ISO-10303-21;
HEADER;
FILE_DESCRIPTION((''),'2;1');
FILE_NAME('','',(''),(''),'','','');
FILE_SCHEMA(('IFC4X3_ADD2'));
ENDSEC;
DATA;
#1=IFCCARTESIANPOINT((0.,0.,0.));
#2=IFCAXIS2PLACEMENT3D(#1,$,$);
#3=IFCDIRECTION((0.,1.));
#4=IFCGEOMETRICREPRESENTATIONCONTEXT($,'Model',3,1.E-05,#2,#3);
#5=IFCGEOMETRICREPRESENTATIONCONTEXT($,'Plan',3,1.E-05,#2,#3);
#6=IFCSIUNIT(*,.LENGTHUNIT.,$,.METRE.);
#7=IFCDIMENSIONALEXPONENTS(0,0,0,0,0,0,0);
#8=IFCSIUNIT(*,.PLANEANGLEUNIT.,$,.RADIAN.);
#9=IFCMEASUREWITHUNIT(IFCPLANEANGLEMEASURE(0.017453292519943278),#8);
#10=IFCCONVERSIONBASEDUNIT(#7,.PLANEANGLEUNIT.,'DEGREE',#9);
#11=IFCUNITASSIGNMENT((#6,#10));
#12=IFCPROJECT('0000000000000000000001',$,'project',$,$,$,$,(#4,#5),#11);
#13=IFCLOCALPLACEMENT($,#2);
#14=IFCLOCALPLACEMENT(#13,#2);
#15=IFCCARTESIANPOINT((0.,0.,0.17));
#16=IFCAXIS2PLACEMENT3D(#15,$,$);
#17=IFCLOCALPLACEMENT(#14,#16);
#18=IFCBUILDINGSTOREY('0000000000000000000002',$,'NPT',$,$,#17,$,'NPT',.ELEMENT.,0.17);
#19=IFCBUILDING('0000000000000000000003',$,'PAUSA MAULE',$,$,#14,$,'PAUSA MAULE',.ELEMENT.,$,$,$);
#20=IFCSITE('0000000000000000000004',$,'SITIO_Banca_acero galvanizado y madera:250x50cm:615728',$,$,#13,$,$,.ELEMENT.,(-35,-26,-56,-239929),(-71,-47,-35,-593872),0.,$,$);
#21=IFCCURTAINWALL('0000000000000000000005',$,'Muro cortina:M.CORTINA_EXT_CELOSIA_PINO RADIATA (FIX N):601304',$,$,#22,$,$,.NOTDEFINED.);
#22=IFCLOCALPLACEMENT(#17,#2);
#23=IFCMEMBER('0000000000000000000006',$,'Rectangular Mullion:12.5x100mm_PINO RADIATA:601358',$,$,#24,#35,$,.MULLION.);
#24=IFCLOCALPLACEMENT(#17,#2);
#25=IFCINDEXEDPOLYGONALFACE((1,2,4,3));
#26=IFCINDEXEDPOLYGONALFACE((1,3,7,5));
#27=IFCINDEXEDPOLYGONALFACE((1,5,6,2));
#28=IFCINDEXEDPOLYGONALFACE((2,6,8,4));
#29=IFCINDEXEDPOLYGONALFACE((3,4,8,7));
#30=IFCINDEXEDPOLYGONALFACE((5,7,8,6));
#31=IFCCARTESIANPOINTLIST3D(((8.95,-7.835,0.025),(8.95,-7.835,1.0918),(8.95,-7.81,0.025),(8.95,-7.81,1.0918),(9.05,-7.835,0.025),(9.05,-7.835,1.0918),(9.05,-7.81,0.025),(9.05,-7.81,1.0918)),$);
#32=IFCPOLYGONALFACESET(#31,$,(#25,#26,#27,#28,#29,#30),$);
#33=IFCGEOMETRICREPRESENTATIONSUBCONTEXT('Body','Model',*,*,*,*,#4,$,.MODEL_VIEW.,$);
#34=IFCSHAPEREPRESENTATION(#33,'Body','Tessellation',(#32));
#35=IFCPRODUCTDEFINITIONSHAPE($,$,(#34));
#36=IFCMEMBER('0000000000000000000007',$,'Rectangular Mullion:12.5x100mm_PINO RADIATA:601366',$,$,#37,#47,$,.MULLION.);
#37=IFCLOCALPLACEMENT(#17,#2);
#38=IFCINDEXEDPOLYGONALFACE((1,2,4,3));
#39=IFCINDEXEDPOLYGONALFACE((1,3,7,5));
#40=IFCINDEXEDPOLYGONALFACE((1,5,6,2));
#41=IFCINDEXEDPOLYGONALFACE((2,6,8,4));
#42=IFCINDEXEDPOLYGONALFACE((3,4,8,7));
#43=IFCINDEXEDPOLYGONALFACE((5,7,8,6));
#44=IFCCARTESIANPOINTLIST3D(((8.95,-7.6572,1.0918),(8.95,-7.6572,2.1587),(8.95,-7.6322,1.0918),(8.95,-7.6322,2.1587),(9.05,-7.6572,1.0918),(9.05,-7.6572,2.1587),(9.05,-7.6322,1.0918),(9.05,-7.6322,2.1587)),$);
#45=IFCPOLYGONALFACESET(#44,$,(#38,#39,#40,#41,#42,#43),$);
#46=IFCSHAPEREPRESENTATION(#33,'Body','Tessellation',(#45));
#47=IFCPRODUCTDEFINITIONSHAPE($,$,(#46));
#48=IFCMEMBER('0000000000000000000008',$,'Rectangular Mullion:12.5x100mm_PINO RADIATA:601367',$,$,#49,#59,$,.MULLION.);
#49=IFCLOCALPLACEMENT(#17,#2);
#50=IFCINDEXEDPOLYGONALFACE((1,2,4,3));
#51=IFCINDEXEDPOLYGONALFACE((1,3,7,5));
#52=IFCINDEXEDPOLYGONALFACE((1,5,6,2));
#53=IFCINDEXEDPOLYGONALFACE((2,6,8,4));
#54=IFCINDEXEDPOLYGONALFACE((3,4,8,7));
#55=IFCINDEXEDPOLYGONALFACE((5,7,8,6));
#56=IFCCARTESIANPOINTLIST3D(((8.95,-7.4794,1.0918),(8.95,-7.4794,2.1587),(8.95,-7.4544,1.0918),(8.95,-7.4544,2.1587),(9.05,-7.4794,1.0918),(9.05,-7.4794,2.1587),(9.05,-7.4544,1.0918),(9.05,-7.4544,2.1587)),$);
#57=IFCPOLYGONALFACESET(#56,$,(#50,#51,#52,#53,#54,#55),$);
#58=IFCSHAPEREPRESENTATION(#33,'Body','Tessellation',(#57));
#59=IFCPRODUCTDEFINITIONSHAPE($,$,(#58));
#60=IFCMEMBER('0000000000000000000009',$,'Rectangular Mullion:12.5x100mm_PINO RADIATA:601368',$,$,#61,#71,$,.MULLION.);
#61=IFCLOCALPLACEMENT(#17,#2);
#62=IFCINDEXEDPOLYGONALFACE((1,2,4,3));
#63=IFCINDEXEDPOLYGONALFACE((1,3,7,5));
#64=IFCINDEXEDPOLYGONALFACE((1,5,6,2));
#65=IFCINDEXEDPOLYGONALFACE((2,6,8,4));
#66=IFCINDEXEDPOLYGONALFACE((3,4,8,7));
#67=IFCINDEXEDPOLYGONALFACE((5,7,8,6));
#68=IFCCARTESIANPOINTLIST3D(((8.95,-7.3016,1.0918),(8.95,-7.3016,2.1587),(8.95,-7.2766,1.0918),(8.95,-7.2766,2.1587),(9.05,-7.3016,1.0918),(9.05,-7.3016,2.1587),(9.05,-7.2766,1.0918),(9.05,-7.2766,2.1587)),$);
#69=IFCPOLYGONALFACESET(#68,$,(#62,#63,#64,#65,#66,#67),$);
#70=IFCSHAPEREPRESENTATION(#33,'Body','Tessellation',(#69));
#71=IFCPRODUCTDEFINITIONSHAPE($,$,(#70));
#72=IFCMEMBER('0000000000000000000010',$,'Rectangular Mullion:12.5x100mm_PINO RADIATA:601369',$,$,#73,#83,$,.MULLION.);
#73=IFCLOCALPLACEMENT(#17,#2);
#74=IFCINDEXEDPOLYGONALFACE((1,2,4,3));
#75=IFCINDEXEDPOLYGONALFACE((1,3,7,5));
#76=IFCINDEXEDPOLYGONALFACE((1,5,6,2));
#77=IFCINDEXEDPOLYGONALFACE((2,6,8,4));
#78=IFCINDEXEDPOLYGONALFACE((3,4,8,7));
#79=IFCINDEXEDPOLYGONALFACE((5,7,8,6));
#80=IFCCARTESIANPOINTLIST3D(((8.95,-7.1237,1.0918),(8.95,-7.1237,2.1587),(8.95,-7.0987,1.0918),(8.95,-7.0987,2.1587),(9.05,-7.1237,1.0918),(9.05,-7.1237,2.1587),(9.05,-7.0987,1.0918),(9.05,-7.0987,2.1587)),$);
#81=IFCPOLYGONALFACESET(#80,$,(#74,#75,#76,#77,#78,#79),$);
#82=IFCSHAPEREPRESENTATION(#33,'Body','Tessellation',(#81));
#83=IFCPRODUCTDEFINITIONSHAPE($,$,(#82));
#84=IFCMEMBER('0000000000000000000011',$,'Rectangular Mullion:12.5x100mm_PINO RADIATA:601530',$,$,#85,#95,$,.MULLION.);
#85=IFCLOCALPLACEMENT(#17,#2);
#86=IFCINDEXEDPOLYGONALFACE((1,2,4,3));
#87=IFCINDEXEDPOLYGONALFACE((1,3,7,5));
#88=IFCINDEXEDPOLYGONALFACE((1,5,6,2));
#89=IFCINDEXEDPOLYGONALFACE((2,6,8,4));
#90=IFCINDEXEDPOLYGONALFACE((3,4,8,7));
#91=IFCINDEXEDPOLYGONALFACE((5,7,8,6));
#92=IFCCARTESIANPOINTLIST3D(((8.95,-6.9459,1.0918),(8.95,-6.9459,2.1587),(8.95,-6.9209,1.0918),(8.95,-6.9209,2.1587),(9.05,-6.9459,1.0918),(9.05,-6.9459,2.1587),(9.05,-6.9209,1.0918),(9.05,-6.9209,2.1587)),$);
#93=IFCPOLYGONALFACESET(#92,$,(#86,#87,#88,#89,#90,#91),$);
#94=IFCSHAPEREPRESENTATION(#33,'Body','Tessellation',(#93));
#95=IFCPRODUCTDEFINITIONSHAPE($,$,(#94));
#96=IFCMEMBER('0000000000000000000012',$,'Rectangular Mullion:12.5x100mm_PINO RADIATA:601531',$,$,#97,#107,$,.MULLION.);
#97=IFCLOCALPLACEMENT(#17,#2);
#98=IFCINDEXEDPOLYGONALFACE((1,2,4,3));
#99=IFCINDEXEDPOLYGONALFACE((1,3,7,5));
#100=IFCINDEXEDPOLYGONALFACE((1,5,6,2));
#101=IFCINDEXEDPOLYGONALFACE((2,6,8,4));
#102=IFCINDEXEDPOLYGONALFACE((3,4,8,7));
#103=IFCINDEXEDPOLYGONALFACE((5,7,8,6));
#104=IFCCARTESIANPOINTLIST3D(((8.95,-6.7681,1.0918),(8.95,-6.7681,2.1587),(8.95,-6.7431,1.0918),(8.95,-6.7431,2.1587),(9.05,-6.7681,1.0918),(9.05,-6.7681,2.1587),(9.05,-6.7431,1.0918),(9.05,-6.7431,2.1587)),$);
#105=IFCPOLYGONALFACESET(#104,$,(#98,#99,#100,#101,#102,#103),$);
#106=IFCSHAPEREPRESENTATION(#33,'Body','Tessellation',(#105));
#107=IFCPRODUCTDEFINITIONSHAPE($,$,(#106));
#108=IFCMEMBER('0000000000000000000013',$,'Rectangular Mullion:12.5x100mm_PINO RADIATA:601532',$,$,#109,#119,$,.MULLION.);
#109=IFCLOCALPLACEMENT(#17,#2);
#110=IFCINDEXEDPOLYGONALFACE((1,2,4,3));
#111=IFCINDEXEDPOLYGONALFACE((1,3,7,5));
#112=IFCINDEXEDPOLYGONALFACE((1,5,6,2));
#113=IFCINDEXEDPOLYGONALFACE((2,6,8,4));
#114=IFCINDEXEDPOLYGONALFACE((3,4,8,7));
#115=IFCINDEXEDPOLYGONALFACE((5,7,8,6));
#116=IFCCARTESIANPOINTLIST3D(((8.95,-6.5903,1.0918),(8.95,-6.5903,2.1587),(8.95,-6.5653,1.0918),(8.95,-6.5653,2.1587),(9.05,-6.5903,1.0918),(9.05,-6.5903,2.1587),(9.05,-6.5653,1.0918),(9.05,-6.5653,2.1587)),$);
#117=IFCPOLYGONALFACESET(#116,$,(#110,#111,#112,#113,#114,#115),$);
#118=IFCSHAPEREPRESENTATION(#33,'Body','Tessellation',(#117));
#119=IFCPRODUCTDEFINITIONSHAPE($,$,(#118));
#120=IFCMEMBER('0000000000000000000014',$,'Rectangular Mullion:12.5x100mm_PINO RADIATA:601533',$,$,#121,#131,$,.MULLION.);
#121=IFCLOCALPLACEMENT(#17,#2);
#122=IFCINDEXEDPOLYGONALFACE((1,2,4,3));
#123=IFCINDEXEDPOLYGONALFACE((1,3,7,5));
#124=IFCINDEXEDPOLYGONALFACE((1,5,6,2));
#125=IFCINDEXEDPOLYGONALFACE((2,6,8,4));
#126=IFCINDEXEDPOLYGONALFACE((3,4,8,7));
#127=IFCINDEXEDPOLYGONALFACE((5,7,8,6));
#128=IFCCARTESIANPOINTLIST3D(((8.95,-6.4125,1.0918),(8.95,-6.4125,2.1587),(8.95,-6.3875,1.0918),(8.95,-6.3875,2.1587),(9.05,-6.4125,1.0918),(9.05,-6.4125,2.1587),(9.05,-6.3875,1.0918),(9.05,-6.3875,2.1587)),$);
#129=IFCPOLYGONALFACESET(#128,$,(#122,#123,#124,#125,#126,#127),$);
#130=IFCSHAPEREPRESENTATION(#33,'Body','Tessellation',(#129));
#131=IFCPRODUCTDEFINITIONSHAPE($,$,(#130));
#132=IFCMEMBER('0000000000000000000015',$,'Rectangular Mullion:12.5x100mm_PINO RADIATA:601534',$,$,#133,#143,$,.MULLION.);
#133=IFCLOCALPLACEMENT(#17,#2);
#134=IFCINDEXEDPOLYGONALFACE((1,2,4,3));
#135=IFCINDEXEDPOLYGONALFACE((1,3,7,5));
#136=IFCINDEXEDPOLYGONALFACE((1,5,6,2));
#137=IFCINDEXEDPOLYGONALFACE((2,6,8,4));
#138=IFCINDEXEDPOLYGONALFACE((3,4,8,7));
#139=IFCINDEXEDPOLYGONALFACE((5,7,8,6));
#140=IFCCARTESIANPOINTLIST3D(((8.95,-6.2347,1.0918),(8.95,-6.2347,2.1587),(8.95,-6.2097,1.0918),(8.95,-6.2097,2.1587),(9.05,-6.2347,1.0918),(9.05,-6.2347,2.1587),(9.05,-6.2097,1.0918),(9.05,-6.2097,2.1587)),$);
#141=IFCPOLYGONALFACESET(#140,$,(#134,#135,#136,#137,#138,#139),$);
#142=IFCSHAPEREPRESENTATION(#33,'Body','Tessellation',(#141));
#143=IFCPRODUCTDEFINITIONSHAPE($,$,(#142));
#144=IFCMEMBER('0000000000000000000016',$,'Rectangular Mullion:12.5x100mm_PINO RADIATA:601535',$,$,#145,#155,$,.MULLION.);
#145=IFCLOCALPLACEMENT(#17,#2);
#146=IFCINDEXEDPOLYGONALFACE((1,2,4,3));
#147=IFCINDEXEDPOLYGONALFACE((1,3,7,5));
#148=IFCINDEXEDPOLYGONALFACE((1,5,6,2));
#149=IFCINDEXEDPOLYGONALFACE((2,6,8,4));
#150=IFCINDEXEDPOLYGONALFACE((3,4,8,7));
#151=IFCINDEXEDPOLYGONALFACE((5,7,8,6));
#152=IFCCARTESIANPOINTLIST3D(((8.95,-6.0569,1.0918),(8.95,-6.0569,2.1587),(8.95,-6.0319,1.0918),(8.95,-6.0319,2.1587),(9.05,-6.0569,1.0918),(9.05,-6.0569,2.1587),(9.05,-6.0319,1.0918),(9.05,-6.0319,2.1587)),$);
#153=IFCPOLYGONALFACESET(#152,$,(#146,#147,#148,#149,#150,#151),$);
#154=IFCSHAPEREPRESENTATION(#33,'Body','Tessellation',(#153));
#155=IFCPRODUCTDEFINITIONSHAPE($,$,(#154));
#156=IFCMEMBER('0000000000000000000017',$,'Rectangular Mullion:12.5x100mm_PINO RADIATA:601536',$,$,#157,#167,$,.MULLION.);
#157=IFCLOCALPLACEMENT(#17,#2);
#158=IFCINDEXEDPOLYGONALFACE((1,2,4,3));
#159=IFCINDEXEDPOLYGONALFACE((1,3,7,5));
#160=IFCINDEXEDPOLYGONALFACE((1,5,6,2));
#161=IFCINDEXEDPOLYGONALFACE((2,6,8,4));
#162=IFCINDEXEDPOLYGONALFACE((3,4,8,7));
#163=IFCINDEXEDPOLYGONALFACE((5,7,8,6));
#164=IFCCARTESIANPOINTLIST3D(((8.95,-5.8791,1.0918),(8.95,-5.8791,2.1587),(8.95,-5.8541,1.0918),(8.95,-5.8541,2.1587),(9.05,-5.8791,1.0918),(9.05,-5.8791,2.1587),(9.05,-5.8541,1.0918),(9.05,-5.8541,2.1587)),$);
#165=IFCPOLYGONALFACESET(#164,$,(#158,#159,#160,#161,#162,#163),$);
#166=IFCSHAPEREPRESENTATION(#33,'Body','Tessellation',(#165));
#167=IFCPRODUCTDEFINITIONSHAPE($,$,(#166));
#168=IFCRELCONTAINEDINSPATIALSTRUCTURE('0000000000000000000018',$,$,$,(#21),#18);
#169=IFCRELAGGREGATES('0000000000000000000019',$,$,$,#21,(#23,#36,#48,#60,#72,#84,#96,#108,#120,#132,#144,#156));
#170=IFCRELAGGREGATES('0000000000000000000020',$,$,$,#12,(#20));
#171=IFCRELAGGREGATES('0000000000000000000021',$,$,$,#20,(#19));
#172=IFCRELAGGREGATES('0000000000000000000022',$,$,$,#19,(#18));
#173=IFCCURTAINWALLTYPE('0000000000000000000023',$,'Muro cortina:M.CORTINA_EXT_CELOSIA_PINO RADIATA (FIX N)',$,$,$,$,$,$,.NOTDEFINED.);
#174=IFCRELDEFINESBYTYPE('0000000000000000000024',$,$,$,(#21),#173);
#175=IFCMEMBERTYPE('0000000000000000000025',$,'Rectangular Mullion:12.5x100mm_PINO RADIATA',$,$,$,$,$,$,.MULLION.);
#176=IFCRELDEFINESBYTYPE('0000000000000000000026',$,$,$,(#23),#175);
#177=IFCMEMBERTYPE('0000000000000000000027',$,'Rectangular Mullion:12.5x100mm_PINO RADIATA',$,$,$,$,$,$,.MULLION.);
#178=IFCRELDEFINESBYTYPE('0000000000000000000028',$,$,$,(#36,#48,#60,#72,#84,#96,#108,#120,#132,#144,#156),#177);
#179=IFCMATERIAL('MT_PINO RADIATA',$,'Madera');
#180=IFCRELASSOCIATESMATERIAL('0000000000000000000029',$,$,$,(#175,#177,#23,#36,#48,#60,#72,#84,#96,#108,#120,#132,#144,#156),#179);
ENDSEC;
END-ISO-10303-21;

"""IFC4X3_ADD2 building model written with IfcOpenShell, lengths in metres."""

from ifc_helpers import new_model, entity, si_unit, converted_unit, direction, frame, frame_2d, origin, origin_2d_with_axis, place, context, subcontext, project, spatial, rectangle, extrude, source, transform, mapped, material, material_profile, profile_set, profile_usage, type_object, type_shapes, element, aggregate, save


model = new_model("IFC4X3_ADD2")

# Units and contexts
model_context = context("Model", 3, precision=1e-05, world=origin(), true_north=direction((0.0, 1.0)))
plan_context = context("Plan", 3, precision=1e-05, world=origin(), true_north=direction((0.0, 1.0)))
body_context = subcontext(model_context, "Body", "Model", "MODEL_VIEW")
ifc_project = project(units=[si_unit("LENGTHUNIT", "METRE"), converted_unit("PLANEANGLEUNIT", "DEGREE", entity("IfcPlaneAngleMeasure", 0.017453292519943278), si_unit("PLANEANGLEUNIT", "RADIAN"), dimensions=[0, 0, 0, 0, 0, 0, 0])], contexts=[model_context, plan_context])

# Site, building, storey
site_placement = place(None, origin())
site = spatial("IfcSite", under=ifc_project, at=site_placement, Name="SITIO_Banca_acero galvanizado y madera:250x50cm:615728", CompositionType="ELEMENT", RefLatitude=(-35, -26, -56, -239929), RefLongitude=(-71, -47, -35, -593872), RefElevation=0.0)
building_placement = place(site_placement, origin())
building = spatial("IfcBuilding", under=site, at=building_placement, Name="PAUSA MAULE", LongName="PAUSA MAULE", CompositionType="ELEMENT")
storey_placement = place(building_placement, frame((0.0, 0.0, 0.17)))
storey = spatial("IfcBuildingStorey", under=building, at=storey_placement, Name="NPT", LongName="NPT", CompositionType="ELEMENT", Elevation=0.17)

# Curtain wall, members
curtain_wall_type = type_object("IfcCurtainWallType", Name="Muro cortina:M.CORTINA_EXT_CELOSIA_PINO RADIATA (FIX N)", PredefinedType="NOTDEFINED")
curtain_wall_placement = place(storey_placement, frame((0.0, 0.0, -0.17)))
curtain_wall = element("IfcCurtainWall", 1, at=curtain_wall_placement, inside=storey, type_object=curtain_wall_type, Name="Muro cortina:M.CORTINA_EXT_CELOSIA_PINO RADIATA (FIX N):601304", PredefinedType="NOTDEFINED")
ifc_material = material(Name="MT_PINO RADIATA", Category="Madera")
ifc_material_profile = material_profile(ifc_material, rectangle(XDim=0.025, YDim=0.1, at=frame_2d((0.0, 0.0), x_axis=(1.0, 0.0))), Name="12.5x100mm_PINO RADIATA")
ifc_profile_set = profile_set([ifc_material_profile], Name="12.5x100mm_PINO RADIATA")
ifc_profile_usage = profile_usage(ifc_profile_set)
member_type_1 = type_object("IfcMemberType", Name="Rectangular Mullion:12.5x100mm_PINO RADIATA", PredefinedType="MULLION", material=ifc_profile_set)
shared_shape_1 = source(origin(), body_context, "Body", "SweptSolid", [
    extrude(rectangle(XDim=0.025, YDim=0.1, at=frame_2d((0.0, 0.0), x_axis=(1.0, 0.0))), frame((-0.0125, 0.0, -1.0668), z_axis=(0.0, 0.0, 1.0), x_axis=(-1.0, 0.0, 0.0)), (0.0, 0.0, 1.0), 1.0668),
])
type_shapes(member_type_1, [shared_shape_1])
member_1_placement = place(curtain_wall_placement, frame((9.0, -7.835, 1.2618), z_axis=(0.0, 0.0, 1.0), x_axis=(0.0, -1.0, 0.0)))
member_1 = element("IfcMember", 2, at=member_1_placement, type_object=member_type_1, material=ifc_profile_usage, Name="Rectangular Mullion:12.5x100mm_PINO RADIATA:601358", PredefinedType="MULLION", context=body_context, shape_type="MappedRepresentation", body=[
    mapped(shared_shape_1, transform((0.0, 0.0, 0.0), scale=1.0)),
])
member_type_2 = type_object("IfcMemberType", Name="Rectangular Mullion:12.5x100mm_PINO RADIATA", PredefinedType="MULLION", material=ifc_profile_set)
shared_shape_2 = source(origin(), body_context, "Body", "SweptSolid", [
    extrude(rectangle(XDim=0.025, YDim=0.1, at=origin_2d_with_axis()), frame((0.0, 0.0, -1.0668), z_axis=(0.0, 0.0, 1.0), x_axis=(-1.0, 0.0, 0.0)), (0.0, 0.0, 1.0), 1.0668),
])
type_shapes(member_type_2, [shared_shape_2])
member_2_placement = place(curtain_wall_placement, frame((9.0, -7.6447, 1.2618), z_axis=(0.0, 0.0, -1.0), x_axis=(0.0, 1.0, 0.0)))
member_2 = element("IfcMember", 3, at=member_2_placement, type_object=member_type_2, material=ifc_profile_usage, Name="Rectangular Mullion:12.5x100mm_PINO RADIATA:601366", PredefinedType="MULLION", context=body_context, shape_type="MappedRepresentation", body=[
    mapped(shared_shape_2, transform((0.0, 0.0, 0.0), scale=1.0)),
])
member_3_placement = place(curtain_wall_placement, frame((9.0, -7.4669, 1.2618), z_axis=(0.0, 0.0, -1.0), x_axis=(0.0, 1.0, 0.0)))
member_3 = element("IfcMember", 4, at=member_3_placement, type_object=member_type_2, material=ifc_profile_usage, Name="Rectangular Mullion:12.5x100mm_PINO RADIATA:601367", PredefinedType="MULLION", context=body_context, shape_type="MappedRepresentation", body=[
    mapped(shared_shape_2, transform((0.0, 0.0, 0.0), scale=1.0)),
])
member_4_placement = place(curtain_wall_placement, frame((9.0, -7.2891, 1.2618), z_axis=(0.0, 0.0, -1.0), x_axis=(0.0, 1.0, 0.0)))
member_4 = element("IfcMember", 5, at=member_4_placement, type_object=member_type_2, material=ifc_profile_usage, Name="Rectangular Mullion:12.5x100mm_PINO RADIATA:601368", PredefinedType="MULLION", context=body_context, shape_type="MappedRepresentation", body=[
    mapped(shared_shape_2, transform((0.0, 0.0, 0.0), scale=1.0)),
])
member_5_placement = place(curtain_wall_placement, frame((9.0, -7.1112, 1.2618), z_axis=(0.0, 0.0, -1.0), x_axis=(0.0, 1.0, 0.0)))
member_5 = element("IfcMember", 6, at=member_5_placement, type_object=member_type_2, material=ifc_profile_usage, Name="Rectangular Mullion:12.5x100mm_PINO RADIATA:601369", PredefinedType="MULLION", context=body_context, shape_type="MappedRepresentation", body=[
    mapped(shared_shape_2, transform((0.0, 0.0, 0.0), scale=1.0)),
])
member_6_placement = place(curtain_wall_placement, frame((9.0, -6.9334, 1.2618), z_axis=(0.0, 0.0, -1.0), x_axis=(0.0, 1.0, 0.0)))
member_6 = element("IfcMember", 7, at=member_6_placement, type_object=member_type_2, material=ifc_profile_usage, Name="Rectangular Mullion:12.5x100mm_PINO RADIATA:601530", PredefinedType="MULLION", context=body_context, shape_type="MappedRepresentation", body=[
    mapped(shared_shape_2, transform((0.0, 0.0, 0.0), scale=1.0)),
])
member_7_placement = place(curtain_wall_placement, frame((9.0, -6.7556, 1.2618), z_axis=(0.0, 0.0, -1.0), x_axis=(0.0, 1.0, 0.0)))
member_7 = element("IfcMember", 8, at=member_7_placement, type_object=member_type_2, material=ifc_profile_usage, Name="Rectangular Mullion:12.5x100mm_PINO RADIATA:601531", PredefinedType="MULLION", context=body_context, shape_type="MappedRepresentation", body=[
    mapped(shared_shape_2, transform((0.0, 0.0, 0.0), scale=1.0)),
])
member_8_placement = place(curtain_wall_placement, frame((9.0, -6.5778, 1.2618), z_axis=(0.0, 0.0, -1.0), x_axis=(0.0, 1.0, 0.0)))
member_8 = element("IfcMember", 9, at=member_8_placement, type_object=member_type_2, material=ifc_profile_usage, Name="Rectangular Mullion:12.5x100mm_PINO RADIATA:601532", PredefinedType="MULLION", context=body_context, shape_type="MappedRepresentation", body=[
    mapped(shared_shape_2, transform((0.0, 0.0, 0.0), scale=1.0)),
])
member_9_placement = place(curtain_wall_placement, frame((9.0, -6.4, 1.2618), z_axis=(0.0, 0.0, -1.0), x_axis=(0.0, 1.0, 0.0)))
member_9 = element("IfcMember", 10, at=member_9_placement, type_object=member_type_2, material=ifc_profile_usage, Name="Rectangular Mullion:12.5x100mm_PINO RADIATA:601533", PredefinedType="MULLION", context=body_context, shape_type="MappedRepresentation", body=[
    mapped(shared_shape_2, transform((0.0, 0.0, 0.0), scale=1.0)),
])
member_10_placement = place(curtain_wall_placement, frame((9.0, -6.2222, 1.2618), z_axis=(0.0, 0.0, -1.0), x_axis=(0.0, 1.0, 0.0)))
member_10 = element("IfcMember", 11, at=member_10_placement, type_object=member_type_2, material=ifc_profile_usage, Name="Rectangular Mullion:12.5x100mm_PINO RADIATA:601534", PredefinedType="MULLION", context=body_context, shape_type="MappedRepresentation", body=[
    mapped(shared_shape_2, transform((0.0, 0.0, 0.0), scale=1.0)),
])
member_11_placement = place(curtain_wall_placement, frame((9.0, -6.0444, 1.2618), z_axis=(0.0, 0.0, -1.0), x_axis=(0.0, 1.0, 0.0)))
member_11 = element("IfcMember", 12, at=member_11_placement, type_object=member_type_2, material=ifc_profile_usage, Name="Rectangular Mullion:12.5x100mm_PINO RADIATA:601535", PredefinedType="MULLION", context=body_context, shape_type="MappedRepresentation", body=[
    mapped(shared_shape_2, transform((0.0, 0.0, 0.0), scale=1.0)),
])
member_12_placement = place(curtain_wall_placement, frame((9.0, -5.8666, 1.2618), z_axis=(0.0, 0.0, -1.0), x_axis=(0.0, 1.0, 0.0)))
member_12 = element("IfcMember", 13, at=member_12_placement, type_object=member_type_2, material=ifc_profile_usage, Name="Rectangular Mullion:12.5x100mm_PINO RADIATA:601536", PredefinedType="MULLION", context=body_context, shape_type="MappedRepresentation", body=[
    mapped(shared_shape_2, transform((0.0, 0.0, 0.0), scale=1.0)),
])
aggregate(curtain_wall, [member_1, member_2, member_3, member_4, member_5, member_6, member_7, member_8, member_9, member_10, member_11, member_12])

save(model, "model.ifc")
